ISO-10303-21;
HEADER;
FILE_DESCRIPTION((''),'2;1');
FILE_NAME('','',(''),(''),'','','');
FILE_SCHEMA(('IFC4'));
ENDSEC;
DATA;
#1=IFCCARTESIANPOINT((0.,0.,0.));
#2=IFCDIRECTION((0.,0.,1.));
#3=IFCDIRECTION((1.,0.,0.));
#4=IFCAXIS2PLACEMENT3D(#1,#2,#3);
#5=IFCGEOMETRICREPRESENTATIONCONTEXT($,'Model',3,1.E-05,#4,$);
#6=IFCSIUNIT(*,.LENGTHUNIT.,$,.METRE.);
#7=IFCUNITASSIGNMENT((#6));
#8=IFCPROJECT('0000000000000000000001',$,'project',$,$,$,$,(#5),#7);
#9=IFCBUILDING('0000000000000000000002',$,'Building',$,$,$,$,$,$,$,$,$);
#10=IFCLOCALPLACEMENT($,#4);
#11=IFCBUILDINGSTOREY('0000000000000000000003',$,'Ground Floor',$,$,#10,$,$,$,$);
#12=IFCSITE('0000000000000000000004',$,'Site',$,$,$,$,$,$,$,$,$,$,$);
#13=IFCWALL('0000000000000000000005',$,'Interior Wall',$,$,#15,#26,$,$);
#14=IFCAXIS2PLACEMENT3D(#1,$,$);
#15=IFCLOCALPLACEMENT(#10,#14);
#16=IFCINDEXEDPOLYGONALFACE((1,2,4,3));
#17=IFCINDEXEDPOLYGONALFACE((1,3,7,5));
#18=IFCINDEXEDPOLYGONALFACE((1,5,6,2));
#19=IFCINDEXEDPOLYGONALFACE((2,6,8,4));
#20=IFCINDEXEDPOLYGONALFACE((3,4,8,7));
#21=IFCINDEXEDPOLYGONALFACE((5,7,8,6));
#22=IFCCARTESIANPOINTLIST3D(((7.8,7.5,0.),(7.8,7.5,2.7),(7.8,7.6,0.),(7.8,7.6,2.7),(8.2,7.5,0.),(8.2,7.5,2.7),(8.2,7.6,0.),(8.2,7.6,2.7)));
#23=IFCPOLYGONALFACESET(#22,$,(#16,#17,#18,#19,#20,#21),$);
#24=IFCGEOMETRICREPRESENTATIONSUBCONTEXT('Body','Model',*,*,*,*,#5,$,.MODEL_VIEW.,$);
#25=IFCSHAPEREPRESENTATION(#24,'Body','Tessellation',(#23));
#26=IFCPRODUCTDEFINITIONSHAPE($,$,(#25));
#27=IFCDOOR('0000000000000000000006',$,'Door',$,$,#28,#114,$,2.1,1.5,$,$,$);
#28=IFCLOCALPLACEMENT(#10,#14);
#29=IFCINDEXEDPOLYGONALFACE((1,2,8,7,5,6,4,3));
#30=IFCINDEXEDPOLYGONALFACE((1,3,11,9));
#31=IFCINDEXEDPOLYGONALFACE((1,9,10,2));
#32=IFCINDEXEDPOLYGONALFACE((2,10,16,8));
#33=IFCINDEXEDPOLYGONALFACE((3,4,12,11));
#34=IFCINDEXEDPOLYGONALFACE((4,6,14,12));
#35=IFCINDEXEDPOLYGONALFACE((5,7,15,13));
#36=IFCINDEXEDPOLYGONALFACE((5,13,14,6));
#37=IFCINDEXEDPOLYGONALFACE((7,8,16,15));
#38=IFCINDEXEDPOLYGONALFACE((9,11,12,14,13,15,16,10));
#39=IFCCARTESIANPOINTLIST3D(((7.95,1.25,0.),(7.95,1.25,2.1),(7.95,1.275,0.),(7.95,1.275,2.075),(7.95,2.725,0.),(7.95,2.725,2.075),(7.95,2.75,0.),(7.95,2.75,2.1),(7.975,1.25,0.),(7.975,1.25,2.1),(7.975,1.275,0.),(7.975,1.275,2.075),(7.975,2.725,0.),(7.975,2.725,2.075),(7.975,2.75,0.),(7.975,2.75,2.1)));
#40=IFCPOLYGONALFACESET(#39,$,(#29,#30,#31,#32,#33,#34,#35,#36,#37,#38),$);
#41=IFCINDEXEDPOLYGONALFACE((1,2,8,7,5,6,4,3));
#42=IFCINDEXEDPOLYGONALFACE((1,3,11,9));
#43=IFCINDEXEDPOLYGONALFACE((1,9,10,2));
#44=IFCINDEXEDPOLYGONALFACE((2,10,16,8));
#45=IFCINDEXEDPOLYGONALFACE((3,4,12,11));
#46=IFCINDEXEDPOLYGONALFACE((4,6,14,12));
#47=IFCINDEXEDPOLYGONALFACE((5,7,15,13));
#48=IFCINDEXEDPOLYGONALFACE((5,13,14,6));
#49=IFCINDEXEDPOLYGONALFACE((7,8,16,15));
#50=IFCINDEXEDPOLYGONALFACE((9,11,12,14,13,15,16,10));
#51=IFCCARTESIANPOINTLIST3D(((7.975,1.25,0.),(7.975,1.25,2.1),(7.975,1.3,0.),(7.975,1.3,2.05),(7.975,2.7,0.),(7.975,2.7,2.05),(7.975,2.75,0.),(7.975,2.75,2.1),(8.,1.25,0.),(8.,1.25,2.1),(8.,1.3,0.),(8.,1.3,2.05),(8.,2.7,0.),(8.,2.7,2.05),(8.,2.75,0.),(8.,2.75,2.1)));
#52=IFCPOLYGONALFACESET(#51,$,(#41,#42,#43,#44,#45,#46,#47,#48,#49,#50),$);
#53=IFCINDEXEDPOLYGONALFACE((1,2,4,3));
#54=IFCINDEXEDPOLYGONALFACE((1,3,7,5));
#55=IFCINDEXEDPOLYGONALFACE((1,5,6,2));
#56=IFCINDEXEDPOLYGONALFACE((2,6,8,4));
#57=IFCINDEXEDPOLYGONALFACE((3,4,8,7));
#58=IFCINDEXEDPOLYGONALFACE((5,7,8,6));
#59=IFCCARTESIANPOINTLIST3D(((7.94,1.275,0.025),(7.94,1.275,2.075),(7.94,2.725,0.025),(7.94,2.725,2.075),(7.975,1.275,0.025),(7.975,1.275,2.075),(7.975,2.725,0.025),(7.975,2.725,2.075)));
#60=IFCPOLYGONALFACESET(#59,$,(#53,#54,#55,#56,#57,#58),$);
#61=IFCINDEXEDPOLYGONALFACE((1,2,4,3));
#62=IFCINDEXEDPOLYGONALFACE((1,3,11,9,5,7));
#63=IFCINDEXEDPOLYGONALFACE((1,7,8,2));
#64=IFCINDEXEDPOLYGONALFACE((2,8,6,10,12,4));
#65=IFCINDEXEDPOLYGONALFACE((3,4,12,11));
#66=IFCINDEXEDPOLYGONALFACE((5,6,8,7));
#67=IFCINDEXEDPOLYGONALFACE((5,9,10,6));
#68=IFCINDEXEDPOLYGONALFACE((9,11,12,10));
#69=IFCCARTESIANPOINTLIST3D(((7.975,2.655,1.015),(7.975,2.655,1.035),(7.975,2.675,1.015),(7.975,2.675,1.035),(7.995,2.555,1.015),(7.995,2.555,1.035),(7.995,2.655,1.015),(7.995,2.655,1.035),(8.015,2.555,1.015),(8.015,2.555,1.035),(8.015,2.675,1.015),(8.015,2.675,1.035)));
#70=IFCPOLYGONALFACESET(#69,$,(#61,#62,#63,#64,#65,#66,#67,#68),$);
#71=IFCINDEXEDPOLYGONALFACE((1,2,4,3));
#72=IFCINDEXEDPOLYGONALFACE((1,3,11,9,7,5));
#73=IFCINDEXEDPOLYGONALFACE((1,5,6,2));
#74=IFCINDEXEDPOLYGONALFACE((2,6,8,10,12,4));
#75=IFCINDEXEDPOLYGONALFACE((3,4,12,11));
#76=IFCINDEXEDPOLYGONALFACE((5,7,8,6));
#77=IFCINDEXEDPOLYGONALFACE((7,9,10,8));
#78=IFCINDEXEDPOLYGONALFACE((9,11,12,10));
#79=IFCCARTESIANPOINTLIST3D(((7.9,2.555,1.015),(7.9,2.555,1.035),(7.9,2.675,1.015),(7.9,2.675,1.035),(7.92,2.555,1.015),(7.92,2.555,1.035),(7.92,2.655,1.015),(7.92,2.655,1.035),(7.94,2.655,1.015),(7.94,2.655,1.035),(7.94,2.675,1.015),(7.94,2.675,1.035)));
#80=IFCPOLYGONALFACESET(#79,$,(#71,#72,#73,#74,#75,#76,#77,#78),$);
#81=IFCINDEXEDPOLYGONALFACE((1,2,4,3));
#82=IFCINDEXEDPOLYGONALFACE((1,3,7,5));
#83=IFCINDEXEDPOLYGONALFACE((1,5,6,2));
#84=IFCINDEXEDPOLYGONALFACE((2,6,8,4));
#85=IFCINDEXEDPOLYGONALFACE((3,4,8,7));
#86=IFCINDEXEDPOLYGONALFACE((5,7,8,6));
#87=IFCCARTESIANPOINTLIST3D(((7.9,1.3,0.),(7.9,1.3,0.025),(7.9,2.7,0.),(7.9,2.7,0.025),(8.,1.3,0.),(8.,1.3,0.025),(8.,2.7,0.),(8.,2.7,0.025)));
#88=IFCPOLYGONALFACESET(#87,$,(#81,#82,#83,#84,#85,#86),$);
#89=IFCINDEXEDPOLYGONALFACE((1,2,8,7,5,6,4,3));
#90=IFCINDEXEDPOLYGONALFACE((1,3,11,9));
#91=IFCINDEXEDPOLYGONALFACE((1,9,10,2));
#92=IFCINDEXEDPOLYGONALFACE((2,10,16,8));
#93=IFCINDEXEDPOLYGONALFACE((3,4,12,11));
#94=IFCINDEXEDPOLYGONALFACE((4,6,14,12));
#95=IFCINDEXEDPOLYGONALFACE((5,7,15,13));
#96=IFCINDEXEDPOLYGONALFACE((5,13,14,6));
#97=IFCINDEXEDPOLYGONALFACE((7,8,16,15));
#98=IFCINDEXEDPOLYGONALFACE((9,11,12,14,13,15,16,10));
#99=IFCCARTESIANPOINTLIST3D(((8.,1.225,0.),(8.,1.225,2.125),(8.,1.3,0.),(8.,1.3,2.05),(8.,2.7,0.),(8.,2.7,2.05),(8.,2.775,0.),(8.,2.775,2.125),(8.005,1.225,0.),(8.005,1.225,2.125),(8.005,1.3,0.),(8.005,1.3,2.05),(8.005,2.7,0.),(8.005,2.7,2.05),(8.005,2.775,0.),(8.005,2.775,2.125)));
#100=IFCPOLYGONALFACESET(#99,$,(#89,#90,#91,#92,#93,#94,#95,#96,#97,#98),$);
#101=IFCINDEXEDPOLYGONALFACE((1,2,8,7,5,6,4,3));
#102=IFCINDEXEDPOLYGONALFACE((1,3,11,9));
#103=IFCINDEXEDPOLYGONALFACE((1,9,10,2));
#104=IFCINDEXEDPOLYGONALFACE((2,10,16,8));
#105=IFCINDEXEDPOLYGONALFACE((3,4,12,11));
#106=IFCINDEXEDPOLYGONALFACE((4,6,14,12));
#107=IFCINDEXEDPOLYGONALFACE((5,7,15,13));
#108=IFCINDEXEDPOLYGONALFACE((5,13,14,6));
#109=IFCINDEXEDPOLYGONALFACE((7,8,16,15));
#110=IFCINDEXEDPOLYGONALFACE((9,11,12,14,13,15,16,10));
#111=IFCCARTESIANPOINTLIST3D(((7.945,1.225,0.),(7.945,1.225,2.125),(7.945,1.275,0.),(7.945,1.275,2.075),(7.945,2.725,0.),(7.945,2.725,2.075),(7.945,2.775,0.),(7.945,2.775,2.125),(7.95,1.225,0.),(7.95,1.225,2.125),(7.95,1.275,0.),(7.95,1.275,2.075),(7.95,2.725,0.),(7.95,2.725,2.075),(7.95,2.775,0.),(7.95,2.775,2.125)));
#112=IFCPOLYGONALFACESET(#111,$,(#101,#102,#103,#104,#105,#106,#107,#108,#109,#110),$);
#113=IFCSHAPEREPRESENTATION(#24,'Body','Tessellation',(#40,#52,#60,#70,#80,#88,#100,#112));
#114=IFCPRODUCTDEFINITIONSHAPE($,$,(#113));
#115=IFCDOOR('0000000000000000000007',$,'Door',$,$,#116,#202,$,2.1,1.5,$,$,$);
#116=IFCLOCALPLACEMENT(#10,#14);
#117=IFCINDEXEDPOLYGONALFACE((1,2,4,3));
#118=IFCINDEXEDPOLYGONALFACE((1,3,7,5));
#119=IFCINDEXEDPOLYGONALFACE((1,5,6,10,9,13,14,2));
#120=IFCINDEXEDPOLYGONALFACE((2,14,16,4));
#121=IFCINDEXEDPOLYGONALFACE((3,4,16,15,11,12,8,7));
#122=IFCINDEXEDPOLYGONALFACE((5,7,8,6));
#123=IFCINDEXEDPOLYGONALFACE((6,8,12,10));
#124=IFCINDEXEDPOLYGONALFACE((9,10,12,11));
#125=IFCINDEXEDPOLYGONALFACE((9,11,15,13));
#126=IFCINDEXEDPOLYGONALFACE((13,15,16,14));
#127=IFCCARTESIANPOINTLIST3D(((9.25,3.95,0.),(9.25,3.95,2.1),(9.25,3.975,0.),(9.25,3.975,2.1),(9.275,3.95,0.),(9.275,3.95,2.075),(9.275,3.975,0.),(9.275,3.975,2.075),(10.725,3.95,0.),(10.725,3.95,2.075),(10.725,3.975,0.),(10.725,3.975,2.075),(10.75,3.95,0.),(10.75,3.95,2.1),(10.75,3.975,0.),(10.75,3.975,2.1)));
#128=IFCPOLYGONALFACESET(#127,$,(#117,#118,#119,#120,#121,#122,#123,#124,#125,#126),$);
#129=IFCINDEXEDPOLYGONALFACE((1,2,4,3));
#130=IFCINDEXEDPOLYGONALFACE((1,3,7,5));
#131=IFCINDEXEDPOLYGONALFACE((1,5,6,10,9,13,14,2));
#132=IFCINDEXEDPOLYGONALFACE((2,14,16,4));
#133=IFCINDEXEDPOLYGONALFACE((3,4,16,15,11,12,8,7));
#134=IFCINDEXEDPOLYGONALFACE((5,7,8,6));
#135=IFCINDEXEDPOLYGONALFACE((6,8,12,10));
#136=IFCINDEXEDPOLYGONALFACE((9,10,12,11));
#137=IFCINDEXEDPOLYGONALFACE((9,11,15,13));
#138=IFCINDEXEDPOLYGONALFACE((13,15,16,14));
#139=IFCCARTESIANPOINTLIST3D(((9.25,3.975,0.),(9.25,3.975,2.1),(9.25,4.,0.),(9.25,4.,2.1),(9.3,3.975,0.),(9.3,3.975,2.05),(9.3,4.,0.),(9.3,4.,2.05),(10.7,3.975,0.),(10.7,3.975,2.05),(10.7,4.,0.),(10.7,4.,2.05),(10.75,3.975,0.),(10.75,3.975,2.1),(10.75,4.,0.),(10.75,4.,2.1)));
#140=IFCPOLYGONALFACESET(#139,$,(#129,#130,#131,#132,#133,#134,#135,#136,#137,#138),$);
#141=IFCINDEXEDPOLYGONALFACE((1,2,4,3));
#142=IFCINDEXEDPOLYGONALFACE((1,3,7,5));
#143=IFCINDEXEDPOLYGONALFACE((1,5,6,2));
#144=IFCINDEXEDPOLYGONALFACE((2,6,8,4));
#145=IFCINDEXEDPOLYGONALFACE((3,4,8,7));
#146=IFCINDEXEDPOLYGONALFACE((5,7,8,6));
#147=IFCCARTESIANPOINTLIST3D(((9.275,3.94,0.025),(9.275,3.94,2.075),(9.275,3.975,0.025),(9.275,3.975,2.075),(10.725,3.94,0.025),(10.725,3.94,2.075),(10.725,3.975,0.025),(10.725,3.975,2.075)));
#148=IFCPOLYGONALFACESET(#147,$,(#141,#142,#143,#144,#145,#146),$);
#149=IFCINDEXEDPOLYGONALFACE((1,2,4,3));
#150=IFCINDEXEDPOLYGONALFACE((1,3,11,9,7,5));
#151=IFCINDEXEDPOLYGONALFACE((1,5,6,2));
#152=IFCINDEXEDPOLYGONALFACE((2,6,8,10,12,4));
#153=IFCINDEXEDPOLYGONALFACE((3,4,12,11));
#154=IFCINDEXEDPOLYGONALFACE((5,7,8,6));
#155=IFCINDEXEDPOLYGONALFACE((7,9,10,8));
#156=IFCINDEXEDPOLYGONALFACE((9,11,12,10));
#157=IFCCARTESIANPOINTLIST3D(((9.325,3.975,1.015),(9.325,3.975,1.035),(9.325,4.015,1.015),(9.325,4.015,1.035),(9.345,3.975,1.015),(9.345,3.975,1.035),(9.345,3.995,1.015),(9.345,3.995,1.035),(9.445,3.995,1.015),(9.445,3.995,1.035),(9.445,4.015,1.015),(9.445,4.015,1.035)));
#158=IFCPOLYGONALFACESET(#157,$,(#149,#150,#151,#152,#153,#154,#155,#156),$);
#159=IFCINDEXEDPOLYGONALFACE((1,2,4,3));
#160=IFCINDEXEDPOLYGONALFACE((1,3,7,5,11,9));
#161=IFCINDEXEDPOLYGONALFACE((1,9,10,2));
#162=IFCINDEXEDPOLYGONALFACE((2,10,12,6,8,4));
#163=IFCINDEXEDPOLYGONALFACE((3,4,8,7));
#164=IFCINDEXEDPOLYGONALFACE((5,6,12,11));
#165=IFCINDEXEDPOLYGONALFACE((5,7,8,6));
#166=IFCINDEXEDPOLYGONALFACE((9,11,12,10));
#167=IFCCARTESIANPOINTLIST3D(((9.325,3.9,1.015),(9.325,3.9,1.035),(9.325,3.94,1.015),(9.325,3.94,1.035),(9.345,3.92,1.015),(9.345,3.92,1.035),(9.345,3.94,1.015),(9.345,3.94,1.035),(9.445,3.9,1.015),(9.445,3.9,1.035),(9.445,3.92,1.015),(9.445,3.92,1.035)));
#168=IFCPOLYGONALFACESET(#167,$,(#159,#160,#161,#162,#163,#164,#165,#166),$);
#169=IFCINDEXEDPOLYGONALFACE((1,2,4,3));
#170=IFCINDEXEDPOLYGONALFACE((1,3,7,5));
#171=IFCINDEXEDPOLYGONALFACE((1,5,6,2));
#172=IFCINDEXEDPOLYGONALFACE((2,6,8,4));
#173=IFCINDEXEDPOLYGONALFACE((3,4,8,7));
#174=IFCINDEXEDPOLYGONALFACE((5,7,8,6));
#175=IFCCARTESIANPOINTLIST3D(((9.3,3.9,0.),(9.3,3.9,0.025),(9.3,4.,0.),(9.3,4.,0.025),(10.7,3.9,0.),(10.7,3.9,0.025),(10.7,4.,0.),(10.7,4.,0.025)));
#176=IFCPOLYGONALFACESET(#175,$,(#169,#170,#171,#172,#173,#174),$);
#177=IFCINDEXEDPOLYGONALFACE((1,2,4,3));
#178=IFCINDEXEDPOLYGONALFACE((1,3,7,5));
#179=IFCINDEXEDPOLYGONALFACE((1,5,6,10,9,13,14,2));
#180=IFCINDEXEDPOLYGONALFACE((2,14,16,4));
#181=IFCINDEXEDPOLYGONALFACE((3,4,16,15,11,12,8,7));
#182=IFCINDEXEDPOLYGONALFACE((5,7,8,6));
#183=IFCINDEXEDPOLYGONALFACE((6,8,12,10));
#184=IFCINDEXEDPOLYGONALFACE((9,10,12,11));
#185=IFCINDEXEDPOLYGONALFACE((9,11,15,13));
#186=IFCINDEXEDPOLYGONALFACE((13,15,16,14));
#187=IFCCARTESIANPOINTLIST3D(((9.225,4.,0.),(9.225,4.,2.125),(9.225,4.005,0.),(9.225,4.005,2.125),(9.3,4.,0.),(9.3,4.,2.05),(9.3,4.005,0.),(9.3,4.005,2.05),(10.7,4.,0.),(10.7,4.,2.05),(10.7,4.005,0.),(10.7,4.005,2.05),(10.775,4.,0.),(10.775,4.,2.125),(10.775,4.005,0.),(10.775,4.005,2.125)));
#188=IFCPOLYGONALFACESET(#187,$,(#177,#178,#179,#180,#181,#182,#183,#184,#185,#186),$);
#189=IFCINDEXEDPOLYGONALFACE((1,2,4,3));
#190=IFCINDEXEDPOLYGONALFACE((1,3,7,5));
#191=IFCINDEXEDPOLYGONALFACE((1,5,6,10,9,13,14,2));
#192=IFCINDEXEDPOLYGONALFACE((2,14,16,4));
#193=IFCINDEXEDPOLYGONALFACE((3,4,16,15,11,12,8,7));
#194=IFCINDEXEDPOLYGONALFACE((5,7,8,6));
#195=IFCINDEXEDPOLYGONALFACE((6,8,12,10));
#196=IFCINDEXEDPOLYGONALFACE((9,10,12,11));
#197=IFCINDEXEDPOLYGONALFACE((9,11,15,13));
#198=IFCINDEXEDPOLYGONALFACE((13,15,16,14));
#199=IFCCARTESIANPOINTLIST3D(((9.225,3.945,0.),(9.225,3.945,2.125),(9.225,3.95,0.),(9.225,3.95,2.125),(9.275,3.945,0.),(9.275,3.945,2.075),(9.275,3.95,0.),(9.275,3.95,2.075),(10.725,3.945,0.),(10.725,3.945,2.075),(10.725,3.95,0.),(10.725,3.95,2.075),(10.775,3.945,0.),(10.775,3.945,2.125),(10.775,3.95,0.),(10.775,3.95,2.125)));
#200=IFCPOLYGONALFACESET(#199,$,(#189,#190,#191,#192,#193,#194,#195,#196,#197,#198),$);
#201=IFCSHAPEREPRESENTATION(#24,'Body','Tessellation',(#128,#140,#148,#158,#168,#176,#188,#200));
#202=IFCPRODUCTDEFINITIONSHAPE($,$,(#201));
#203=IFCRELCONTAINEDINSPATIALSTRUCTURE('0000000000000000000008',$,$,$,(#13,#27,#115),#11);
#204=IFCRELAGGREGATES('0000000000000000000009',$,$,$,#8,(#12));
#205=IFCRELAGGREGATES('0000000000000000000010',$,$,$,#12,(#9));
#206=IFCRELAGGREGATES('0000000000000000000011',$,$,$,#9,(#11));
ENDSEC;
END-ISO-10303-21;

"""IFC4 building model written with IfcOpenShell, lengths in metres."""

from ifc_helpers import new_model, si_unit, frame, origin_with_axes, place, context, subcontext, project, spatial, line, indexed_curve, outline, extrude, element, save


model = new_model("IFC4")

# Units and contexts
model_context = context("Model", 3, precision=1e-05, world=origin_with_axes())
body_context = subcontext(model_context, "Body", "Model", "MODEL_VIEW")
ifc_project = project(units=[si_unit("LENGTHUNIT", "METRE")], contexts=[model_context])

# Site, building, storey
site = spatial("IfcSite", under=ifc_project, Name="Site")
building = spatial("IfcBuilding", under=site, Name="Building")
storey_placement = place(None, origin_with_axes())
storey = spatial("IfcBuildingStorey", under=building, at=storey_placement, Name="Ground Floor")

# Wall
wall_1_placement = place(storey_placement, frame((8.0, 7.5, 0.0), z_axis=(0.0, 0.0, 1.0), x_axis=(0.0, 1.0, 0.0)))
element("IfcWall", 1, at=wall_1_placement, inside=storey, Name="Interior Wall", context=body_context, shape_type="SweptSolid", body=[
    extrude(outline(indexed_curve([(0.0, 0.0), (0.0, 0.4), (0.1, 0.4), (0.1, 0.0), (0.0, 0.0)], self_intersect=False)), frame((0.0, -0.2, 0.0), z_axis=(0.0, 0.0, 1.0), x_axis=(1.0, 0.0, 0.0)), (0.0, 0.0, 1.0), 2.7),
])

# Doors
door_1_placement = place(storey_placement, frame((8.0, 1.25, 0.0), z_axis=(0.0, 0.0, 1.0), x_axis=(0.0, 1.0, 0.0)))
element("IfcDoor", 2, at=door_1_placement, inside=storey, Name="Door", OverallHeight=2.1, OverallWidth=1.5, context=body_context, shape_type="SweptSolid", body=[
    extrude(outline(indexed_curve([(0.0, 0.0), (0.0, 2.1), (1.5, 2.1), (1.5, 0.0), (1.475, 0.0), (1.475, 2.075), (0.025, 2.075), (0.025, 0.0)], segments=[line(1, 2, 3, 4, 5, 6, 7, 8, 1)])), frame((0.0, 0.025, 0.0), z_axis=(0.0, -1.0, 0.0), x_axis=(1.0, 0.0, 0.0)), (0.0, 0.0, -1.0), 0.025),
    extrude(outline(indexed_curve([(0.0, 0.0), (0.0, 2.1), (1.5, 2.1), (1.5, 0.0), (1.45, 0.0), (1.45, 2.05), (0.05, 2.05), (0.05, 0.0)], segments=[line(1, 2, 3, 4, 5, 6, 7, 8, 1)])), frame((0.0, 0.0, 0.0), z_axis=(0.0, -1.0, 0.0), x_axis=(1.0, 0.0, 0.0)), (0.0, 0.0, -1.0), 0.025),
    extrude(outline(indexed_curve([(0.0, 0.0), (1.45, 0.0), (1.45, 0.035), (0.0, 0.035)], segments=[line(1, 2, 3, 4, 1)])), frame((0.025, 0.025, 0.025), z_axis=(0.0, 0.0, 1.0), x_axis=(1.0, 0.0, 0.0)), (0.0, 0.0, 1.0), 2.05),
    extrude(outline(indexed_curve([(0.0, 0.0), (0.0, -0.04), (-0.12, -0.04), (-0.12, -0.02), (-0.02, -0.02), (-0.02, 0.0)], segments=[line(1, 2, 3, 4, 5, 6, 1)])), frame((1.425, 0.025, 1.015), z_axis=(0.0, 0.0, 1.0), x_axis=(1.0, 0.0, 0.0)), (0.0, 0.0, 1.0), 0.02),
    extrude(outline(indexed_curve([(0.0, 0.0), (0.0, 0.04), (-0.12, 0.04), (-0.12, 0.02), (-0.02, 0.02), (-0.02, 0.0)], segments=[line(1, 2, 3, 4, 5, 6, 1)])), frame((1.425, 0.06, 1.015), z_axis=(0.0, 0.0, 1.0), x_axis=(1.0, 0.0, 0.0)), (0.0, 0.0, 1.0), 0.02),
    extrude(outline(indexed_curve([(0.0, 0.0), (1.4, 0.0), (1.4, 0.1), (0.0, 0.1)], segments=[line(1, 2, 3, 4, 1)])), frame((0.05, 0.0, 0.0), z_axis=(0.0, 0.0, 1.0), x_axis=(1.0, 0.0, 0.0)), (0.0, 0.0, 1.0), 0.025),
    extrude(outline(indexed_curve([(0.0, 0.0), (0.0, 2.125), (1.55, 2.125), (1.55, 0.0), (1.475, 0.0), (1.475, 2.05), (0.075, 2.05), (0.075, 0.0)], segments=[line(1, 2, 3, 4, 5, 6, 7, 8, 1)])), frame((-0.025, -0.005, 0.0), z_axis=(0.0, -1.0, 0.0), x_axis=(1.0, 0.0, 0.0)), (0.0, 0.0, -1.0), 0.005),
    extrude(outline(indexed_curve([(0.0, 0.0), (0.0, 2.125), (1.55, 2.125), (1.55, 0.0), (1.5, 0.0), (1.5, 2.075), (0.05, 2.075), (0.05, 0.0)], segments=[line(1, 2, 3, 4, 5, 6, 7, 8, 1)])), frame((-0.025, 0.05, 0.0), z_axis=(0.0, -1.0, 0.0), x_axis=(1.0, 0.0, 0.0)), (0.0, 0.0, -1.0), 0.005),
])
door_2_placement = place(storey_placement, frame((10.75, 4.0, 0.0), z_axis=(0.0, 0.0, 1.0), x_axis=(-1.0, 0.0, 0.0)))
element("IfcDoor", 3, at=door_2_placement, inside=storey, Name="Door", OverallHeight=2.1, OverallWidth=1.5, context=body_context, shape_type="SweptSolid", body=[
    extrude(outline(indexed_curve([(0.0, 0.0), (0.0, 2.1), (1.5, 2.1), (1.5, 0.0), (1.475, 0.0), (1.475, 2.075), (0.025, 2.075), (0.025, 0.0)], segments=[line(1, 2, 3, 4, 5, 6, 7, 8, 1)])), frame((0.0, 0.025, 0.0), z_axis=(0.0, -1.0, 0.0), x_axis=(1.0, 0.0, 0.0)), (0.0, 0.0, -1.0), 0.025),
    extrude(outline(indexed_curve([(0.0, 0.0), (0.0, 2.1), (1.5, 2.1), (1.5, 0.0), (1.45, 0.0), (1.45, 2.05), (0.05, 2.05), (0.05, 0.0)], segments=[line(1, 2, 3, 4, 5, 6, 7, 8, 1)])), frame((0.0, 0.0, 0.0), z_axis=(0.0, -1.0, 0.0), x_axis=(1.0, 0.0, 0.0)), (0.0, 0.0, -1.0), 0.025),
    extrude(outline(indexed_curve([(0.0, 0.0), (1.45, 0.0), (1.45, 0.035), (0.0, 0.035)], segments=[line(1, 2, 3, 4, 1)])), frame((0.025, 0.025, 0.025), z_axis=(0.0, 0.0, 1.0), x_axis=(1.0, 0.0, 0.0)), (0.0, 0.0, 1.0), 2.05),
    extrude(outline(indexed_curve([(0.0, 0.0), (0.0, -0.04), (-0.12, -0.04), (-0.12, -0.02), (-0.02, -0.02), (-0.02, 0.0)], segments=[line(1, 2, 3, 4, 5, 6, 1)])), frame((1.425, 0.025, 1.015), z_axis=(0.0, 0.0, 1.0), x_axis=(1.0, 0.0, 0.0)), (0.0, 0.0, 1.0), 0.02),
    extrude(outline(indexed_curve([(0.0, 0.0), (0.0, 0.04), (-0.12, 0.04), (-0.12, 0.02), (-0.02, 0.02), (-0.02, 0.0)], segments=[line(1, 2, 3, 4, 5, 6, 1)])), frame((1.425, 0.06, 1.015), z_axis=(0.0, 0.0, 1.0), x_axis=(1.0, 0.0, 0.0)), (0.0, 0.0, 1.0), 0.02),
    extrude(outline(indexed_curve([(0.0, 0.0), (1.4, 0.0), (1.4, 0.1), (0.0, 0.1)], segments=[line(1, 2, 3, 4, 1)])), frame((0.05, 0.0, 0.0), z_axis=(0.0, 0.0, 1.0), x_axis=(1.0, 0.0, 0.0)), (0.0, 0.0, 1.0), 0.025),
    extrude(outline(indexed_curve([(0.0, 0.0), (0.0, 2.125), (1.55, 2.125), (1.55, 0.0), (1.475, 0.0), (1.475, 2.05), (0.075, 2.05), (0.075, 0.0)], segments=[line(1, 2, 3, 4, 5, 6, 7, 8, 1)])), frame((-0.025, -0.005, 0.0), z_axis=(0.0, -1.0, 0.0), x_axis=(1.0, 0.0, 0.0)), (0.0, 0.0, -1.0), 0.005),
    extrude(outline(indexed_curve([(0.0, 0.0), (0.0, 2.125), (1.55, 2.125), (1.55, 0.0), (1.5, 0.0), (1.5, 2.075), (0.05, 2.075), (0.05, 0.0)], segments=[line(1, 2, 3, 4, 5, 6, 7, 8, 1)])), frame((-0.025, 0.05, 0.0), z_axis=(0.0, -1.0, 0.0), x_axis=(1.0, 0.0, 0.0)), (0.0, 0.0, -1.0), 0.005),
])

save(model, "model.ifc")
